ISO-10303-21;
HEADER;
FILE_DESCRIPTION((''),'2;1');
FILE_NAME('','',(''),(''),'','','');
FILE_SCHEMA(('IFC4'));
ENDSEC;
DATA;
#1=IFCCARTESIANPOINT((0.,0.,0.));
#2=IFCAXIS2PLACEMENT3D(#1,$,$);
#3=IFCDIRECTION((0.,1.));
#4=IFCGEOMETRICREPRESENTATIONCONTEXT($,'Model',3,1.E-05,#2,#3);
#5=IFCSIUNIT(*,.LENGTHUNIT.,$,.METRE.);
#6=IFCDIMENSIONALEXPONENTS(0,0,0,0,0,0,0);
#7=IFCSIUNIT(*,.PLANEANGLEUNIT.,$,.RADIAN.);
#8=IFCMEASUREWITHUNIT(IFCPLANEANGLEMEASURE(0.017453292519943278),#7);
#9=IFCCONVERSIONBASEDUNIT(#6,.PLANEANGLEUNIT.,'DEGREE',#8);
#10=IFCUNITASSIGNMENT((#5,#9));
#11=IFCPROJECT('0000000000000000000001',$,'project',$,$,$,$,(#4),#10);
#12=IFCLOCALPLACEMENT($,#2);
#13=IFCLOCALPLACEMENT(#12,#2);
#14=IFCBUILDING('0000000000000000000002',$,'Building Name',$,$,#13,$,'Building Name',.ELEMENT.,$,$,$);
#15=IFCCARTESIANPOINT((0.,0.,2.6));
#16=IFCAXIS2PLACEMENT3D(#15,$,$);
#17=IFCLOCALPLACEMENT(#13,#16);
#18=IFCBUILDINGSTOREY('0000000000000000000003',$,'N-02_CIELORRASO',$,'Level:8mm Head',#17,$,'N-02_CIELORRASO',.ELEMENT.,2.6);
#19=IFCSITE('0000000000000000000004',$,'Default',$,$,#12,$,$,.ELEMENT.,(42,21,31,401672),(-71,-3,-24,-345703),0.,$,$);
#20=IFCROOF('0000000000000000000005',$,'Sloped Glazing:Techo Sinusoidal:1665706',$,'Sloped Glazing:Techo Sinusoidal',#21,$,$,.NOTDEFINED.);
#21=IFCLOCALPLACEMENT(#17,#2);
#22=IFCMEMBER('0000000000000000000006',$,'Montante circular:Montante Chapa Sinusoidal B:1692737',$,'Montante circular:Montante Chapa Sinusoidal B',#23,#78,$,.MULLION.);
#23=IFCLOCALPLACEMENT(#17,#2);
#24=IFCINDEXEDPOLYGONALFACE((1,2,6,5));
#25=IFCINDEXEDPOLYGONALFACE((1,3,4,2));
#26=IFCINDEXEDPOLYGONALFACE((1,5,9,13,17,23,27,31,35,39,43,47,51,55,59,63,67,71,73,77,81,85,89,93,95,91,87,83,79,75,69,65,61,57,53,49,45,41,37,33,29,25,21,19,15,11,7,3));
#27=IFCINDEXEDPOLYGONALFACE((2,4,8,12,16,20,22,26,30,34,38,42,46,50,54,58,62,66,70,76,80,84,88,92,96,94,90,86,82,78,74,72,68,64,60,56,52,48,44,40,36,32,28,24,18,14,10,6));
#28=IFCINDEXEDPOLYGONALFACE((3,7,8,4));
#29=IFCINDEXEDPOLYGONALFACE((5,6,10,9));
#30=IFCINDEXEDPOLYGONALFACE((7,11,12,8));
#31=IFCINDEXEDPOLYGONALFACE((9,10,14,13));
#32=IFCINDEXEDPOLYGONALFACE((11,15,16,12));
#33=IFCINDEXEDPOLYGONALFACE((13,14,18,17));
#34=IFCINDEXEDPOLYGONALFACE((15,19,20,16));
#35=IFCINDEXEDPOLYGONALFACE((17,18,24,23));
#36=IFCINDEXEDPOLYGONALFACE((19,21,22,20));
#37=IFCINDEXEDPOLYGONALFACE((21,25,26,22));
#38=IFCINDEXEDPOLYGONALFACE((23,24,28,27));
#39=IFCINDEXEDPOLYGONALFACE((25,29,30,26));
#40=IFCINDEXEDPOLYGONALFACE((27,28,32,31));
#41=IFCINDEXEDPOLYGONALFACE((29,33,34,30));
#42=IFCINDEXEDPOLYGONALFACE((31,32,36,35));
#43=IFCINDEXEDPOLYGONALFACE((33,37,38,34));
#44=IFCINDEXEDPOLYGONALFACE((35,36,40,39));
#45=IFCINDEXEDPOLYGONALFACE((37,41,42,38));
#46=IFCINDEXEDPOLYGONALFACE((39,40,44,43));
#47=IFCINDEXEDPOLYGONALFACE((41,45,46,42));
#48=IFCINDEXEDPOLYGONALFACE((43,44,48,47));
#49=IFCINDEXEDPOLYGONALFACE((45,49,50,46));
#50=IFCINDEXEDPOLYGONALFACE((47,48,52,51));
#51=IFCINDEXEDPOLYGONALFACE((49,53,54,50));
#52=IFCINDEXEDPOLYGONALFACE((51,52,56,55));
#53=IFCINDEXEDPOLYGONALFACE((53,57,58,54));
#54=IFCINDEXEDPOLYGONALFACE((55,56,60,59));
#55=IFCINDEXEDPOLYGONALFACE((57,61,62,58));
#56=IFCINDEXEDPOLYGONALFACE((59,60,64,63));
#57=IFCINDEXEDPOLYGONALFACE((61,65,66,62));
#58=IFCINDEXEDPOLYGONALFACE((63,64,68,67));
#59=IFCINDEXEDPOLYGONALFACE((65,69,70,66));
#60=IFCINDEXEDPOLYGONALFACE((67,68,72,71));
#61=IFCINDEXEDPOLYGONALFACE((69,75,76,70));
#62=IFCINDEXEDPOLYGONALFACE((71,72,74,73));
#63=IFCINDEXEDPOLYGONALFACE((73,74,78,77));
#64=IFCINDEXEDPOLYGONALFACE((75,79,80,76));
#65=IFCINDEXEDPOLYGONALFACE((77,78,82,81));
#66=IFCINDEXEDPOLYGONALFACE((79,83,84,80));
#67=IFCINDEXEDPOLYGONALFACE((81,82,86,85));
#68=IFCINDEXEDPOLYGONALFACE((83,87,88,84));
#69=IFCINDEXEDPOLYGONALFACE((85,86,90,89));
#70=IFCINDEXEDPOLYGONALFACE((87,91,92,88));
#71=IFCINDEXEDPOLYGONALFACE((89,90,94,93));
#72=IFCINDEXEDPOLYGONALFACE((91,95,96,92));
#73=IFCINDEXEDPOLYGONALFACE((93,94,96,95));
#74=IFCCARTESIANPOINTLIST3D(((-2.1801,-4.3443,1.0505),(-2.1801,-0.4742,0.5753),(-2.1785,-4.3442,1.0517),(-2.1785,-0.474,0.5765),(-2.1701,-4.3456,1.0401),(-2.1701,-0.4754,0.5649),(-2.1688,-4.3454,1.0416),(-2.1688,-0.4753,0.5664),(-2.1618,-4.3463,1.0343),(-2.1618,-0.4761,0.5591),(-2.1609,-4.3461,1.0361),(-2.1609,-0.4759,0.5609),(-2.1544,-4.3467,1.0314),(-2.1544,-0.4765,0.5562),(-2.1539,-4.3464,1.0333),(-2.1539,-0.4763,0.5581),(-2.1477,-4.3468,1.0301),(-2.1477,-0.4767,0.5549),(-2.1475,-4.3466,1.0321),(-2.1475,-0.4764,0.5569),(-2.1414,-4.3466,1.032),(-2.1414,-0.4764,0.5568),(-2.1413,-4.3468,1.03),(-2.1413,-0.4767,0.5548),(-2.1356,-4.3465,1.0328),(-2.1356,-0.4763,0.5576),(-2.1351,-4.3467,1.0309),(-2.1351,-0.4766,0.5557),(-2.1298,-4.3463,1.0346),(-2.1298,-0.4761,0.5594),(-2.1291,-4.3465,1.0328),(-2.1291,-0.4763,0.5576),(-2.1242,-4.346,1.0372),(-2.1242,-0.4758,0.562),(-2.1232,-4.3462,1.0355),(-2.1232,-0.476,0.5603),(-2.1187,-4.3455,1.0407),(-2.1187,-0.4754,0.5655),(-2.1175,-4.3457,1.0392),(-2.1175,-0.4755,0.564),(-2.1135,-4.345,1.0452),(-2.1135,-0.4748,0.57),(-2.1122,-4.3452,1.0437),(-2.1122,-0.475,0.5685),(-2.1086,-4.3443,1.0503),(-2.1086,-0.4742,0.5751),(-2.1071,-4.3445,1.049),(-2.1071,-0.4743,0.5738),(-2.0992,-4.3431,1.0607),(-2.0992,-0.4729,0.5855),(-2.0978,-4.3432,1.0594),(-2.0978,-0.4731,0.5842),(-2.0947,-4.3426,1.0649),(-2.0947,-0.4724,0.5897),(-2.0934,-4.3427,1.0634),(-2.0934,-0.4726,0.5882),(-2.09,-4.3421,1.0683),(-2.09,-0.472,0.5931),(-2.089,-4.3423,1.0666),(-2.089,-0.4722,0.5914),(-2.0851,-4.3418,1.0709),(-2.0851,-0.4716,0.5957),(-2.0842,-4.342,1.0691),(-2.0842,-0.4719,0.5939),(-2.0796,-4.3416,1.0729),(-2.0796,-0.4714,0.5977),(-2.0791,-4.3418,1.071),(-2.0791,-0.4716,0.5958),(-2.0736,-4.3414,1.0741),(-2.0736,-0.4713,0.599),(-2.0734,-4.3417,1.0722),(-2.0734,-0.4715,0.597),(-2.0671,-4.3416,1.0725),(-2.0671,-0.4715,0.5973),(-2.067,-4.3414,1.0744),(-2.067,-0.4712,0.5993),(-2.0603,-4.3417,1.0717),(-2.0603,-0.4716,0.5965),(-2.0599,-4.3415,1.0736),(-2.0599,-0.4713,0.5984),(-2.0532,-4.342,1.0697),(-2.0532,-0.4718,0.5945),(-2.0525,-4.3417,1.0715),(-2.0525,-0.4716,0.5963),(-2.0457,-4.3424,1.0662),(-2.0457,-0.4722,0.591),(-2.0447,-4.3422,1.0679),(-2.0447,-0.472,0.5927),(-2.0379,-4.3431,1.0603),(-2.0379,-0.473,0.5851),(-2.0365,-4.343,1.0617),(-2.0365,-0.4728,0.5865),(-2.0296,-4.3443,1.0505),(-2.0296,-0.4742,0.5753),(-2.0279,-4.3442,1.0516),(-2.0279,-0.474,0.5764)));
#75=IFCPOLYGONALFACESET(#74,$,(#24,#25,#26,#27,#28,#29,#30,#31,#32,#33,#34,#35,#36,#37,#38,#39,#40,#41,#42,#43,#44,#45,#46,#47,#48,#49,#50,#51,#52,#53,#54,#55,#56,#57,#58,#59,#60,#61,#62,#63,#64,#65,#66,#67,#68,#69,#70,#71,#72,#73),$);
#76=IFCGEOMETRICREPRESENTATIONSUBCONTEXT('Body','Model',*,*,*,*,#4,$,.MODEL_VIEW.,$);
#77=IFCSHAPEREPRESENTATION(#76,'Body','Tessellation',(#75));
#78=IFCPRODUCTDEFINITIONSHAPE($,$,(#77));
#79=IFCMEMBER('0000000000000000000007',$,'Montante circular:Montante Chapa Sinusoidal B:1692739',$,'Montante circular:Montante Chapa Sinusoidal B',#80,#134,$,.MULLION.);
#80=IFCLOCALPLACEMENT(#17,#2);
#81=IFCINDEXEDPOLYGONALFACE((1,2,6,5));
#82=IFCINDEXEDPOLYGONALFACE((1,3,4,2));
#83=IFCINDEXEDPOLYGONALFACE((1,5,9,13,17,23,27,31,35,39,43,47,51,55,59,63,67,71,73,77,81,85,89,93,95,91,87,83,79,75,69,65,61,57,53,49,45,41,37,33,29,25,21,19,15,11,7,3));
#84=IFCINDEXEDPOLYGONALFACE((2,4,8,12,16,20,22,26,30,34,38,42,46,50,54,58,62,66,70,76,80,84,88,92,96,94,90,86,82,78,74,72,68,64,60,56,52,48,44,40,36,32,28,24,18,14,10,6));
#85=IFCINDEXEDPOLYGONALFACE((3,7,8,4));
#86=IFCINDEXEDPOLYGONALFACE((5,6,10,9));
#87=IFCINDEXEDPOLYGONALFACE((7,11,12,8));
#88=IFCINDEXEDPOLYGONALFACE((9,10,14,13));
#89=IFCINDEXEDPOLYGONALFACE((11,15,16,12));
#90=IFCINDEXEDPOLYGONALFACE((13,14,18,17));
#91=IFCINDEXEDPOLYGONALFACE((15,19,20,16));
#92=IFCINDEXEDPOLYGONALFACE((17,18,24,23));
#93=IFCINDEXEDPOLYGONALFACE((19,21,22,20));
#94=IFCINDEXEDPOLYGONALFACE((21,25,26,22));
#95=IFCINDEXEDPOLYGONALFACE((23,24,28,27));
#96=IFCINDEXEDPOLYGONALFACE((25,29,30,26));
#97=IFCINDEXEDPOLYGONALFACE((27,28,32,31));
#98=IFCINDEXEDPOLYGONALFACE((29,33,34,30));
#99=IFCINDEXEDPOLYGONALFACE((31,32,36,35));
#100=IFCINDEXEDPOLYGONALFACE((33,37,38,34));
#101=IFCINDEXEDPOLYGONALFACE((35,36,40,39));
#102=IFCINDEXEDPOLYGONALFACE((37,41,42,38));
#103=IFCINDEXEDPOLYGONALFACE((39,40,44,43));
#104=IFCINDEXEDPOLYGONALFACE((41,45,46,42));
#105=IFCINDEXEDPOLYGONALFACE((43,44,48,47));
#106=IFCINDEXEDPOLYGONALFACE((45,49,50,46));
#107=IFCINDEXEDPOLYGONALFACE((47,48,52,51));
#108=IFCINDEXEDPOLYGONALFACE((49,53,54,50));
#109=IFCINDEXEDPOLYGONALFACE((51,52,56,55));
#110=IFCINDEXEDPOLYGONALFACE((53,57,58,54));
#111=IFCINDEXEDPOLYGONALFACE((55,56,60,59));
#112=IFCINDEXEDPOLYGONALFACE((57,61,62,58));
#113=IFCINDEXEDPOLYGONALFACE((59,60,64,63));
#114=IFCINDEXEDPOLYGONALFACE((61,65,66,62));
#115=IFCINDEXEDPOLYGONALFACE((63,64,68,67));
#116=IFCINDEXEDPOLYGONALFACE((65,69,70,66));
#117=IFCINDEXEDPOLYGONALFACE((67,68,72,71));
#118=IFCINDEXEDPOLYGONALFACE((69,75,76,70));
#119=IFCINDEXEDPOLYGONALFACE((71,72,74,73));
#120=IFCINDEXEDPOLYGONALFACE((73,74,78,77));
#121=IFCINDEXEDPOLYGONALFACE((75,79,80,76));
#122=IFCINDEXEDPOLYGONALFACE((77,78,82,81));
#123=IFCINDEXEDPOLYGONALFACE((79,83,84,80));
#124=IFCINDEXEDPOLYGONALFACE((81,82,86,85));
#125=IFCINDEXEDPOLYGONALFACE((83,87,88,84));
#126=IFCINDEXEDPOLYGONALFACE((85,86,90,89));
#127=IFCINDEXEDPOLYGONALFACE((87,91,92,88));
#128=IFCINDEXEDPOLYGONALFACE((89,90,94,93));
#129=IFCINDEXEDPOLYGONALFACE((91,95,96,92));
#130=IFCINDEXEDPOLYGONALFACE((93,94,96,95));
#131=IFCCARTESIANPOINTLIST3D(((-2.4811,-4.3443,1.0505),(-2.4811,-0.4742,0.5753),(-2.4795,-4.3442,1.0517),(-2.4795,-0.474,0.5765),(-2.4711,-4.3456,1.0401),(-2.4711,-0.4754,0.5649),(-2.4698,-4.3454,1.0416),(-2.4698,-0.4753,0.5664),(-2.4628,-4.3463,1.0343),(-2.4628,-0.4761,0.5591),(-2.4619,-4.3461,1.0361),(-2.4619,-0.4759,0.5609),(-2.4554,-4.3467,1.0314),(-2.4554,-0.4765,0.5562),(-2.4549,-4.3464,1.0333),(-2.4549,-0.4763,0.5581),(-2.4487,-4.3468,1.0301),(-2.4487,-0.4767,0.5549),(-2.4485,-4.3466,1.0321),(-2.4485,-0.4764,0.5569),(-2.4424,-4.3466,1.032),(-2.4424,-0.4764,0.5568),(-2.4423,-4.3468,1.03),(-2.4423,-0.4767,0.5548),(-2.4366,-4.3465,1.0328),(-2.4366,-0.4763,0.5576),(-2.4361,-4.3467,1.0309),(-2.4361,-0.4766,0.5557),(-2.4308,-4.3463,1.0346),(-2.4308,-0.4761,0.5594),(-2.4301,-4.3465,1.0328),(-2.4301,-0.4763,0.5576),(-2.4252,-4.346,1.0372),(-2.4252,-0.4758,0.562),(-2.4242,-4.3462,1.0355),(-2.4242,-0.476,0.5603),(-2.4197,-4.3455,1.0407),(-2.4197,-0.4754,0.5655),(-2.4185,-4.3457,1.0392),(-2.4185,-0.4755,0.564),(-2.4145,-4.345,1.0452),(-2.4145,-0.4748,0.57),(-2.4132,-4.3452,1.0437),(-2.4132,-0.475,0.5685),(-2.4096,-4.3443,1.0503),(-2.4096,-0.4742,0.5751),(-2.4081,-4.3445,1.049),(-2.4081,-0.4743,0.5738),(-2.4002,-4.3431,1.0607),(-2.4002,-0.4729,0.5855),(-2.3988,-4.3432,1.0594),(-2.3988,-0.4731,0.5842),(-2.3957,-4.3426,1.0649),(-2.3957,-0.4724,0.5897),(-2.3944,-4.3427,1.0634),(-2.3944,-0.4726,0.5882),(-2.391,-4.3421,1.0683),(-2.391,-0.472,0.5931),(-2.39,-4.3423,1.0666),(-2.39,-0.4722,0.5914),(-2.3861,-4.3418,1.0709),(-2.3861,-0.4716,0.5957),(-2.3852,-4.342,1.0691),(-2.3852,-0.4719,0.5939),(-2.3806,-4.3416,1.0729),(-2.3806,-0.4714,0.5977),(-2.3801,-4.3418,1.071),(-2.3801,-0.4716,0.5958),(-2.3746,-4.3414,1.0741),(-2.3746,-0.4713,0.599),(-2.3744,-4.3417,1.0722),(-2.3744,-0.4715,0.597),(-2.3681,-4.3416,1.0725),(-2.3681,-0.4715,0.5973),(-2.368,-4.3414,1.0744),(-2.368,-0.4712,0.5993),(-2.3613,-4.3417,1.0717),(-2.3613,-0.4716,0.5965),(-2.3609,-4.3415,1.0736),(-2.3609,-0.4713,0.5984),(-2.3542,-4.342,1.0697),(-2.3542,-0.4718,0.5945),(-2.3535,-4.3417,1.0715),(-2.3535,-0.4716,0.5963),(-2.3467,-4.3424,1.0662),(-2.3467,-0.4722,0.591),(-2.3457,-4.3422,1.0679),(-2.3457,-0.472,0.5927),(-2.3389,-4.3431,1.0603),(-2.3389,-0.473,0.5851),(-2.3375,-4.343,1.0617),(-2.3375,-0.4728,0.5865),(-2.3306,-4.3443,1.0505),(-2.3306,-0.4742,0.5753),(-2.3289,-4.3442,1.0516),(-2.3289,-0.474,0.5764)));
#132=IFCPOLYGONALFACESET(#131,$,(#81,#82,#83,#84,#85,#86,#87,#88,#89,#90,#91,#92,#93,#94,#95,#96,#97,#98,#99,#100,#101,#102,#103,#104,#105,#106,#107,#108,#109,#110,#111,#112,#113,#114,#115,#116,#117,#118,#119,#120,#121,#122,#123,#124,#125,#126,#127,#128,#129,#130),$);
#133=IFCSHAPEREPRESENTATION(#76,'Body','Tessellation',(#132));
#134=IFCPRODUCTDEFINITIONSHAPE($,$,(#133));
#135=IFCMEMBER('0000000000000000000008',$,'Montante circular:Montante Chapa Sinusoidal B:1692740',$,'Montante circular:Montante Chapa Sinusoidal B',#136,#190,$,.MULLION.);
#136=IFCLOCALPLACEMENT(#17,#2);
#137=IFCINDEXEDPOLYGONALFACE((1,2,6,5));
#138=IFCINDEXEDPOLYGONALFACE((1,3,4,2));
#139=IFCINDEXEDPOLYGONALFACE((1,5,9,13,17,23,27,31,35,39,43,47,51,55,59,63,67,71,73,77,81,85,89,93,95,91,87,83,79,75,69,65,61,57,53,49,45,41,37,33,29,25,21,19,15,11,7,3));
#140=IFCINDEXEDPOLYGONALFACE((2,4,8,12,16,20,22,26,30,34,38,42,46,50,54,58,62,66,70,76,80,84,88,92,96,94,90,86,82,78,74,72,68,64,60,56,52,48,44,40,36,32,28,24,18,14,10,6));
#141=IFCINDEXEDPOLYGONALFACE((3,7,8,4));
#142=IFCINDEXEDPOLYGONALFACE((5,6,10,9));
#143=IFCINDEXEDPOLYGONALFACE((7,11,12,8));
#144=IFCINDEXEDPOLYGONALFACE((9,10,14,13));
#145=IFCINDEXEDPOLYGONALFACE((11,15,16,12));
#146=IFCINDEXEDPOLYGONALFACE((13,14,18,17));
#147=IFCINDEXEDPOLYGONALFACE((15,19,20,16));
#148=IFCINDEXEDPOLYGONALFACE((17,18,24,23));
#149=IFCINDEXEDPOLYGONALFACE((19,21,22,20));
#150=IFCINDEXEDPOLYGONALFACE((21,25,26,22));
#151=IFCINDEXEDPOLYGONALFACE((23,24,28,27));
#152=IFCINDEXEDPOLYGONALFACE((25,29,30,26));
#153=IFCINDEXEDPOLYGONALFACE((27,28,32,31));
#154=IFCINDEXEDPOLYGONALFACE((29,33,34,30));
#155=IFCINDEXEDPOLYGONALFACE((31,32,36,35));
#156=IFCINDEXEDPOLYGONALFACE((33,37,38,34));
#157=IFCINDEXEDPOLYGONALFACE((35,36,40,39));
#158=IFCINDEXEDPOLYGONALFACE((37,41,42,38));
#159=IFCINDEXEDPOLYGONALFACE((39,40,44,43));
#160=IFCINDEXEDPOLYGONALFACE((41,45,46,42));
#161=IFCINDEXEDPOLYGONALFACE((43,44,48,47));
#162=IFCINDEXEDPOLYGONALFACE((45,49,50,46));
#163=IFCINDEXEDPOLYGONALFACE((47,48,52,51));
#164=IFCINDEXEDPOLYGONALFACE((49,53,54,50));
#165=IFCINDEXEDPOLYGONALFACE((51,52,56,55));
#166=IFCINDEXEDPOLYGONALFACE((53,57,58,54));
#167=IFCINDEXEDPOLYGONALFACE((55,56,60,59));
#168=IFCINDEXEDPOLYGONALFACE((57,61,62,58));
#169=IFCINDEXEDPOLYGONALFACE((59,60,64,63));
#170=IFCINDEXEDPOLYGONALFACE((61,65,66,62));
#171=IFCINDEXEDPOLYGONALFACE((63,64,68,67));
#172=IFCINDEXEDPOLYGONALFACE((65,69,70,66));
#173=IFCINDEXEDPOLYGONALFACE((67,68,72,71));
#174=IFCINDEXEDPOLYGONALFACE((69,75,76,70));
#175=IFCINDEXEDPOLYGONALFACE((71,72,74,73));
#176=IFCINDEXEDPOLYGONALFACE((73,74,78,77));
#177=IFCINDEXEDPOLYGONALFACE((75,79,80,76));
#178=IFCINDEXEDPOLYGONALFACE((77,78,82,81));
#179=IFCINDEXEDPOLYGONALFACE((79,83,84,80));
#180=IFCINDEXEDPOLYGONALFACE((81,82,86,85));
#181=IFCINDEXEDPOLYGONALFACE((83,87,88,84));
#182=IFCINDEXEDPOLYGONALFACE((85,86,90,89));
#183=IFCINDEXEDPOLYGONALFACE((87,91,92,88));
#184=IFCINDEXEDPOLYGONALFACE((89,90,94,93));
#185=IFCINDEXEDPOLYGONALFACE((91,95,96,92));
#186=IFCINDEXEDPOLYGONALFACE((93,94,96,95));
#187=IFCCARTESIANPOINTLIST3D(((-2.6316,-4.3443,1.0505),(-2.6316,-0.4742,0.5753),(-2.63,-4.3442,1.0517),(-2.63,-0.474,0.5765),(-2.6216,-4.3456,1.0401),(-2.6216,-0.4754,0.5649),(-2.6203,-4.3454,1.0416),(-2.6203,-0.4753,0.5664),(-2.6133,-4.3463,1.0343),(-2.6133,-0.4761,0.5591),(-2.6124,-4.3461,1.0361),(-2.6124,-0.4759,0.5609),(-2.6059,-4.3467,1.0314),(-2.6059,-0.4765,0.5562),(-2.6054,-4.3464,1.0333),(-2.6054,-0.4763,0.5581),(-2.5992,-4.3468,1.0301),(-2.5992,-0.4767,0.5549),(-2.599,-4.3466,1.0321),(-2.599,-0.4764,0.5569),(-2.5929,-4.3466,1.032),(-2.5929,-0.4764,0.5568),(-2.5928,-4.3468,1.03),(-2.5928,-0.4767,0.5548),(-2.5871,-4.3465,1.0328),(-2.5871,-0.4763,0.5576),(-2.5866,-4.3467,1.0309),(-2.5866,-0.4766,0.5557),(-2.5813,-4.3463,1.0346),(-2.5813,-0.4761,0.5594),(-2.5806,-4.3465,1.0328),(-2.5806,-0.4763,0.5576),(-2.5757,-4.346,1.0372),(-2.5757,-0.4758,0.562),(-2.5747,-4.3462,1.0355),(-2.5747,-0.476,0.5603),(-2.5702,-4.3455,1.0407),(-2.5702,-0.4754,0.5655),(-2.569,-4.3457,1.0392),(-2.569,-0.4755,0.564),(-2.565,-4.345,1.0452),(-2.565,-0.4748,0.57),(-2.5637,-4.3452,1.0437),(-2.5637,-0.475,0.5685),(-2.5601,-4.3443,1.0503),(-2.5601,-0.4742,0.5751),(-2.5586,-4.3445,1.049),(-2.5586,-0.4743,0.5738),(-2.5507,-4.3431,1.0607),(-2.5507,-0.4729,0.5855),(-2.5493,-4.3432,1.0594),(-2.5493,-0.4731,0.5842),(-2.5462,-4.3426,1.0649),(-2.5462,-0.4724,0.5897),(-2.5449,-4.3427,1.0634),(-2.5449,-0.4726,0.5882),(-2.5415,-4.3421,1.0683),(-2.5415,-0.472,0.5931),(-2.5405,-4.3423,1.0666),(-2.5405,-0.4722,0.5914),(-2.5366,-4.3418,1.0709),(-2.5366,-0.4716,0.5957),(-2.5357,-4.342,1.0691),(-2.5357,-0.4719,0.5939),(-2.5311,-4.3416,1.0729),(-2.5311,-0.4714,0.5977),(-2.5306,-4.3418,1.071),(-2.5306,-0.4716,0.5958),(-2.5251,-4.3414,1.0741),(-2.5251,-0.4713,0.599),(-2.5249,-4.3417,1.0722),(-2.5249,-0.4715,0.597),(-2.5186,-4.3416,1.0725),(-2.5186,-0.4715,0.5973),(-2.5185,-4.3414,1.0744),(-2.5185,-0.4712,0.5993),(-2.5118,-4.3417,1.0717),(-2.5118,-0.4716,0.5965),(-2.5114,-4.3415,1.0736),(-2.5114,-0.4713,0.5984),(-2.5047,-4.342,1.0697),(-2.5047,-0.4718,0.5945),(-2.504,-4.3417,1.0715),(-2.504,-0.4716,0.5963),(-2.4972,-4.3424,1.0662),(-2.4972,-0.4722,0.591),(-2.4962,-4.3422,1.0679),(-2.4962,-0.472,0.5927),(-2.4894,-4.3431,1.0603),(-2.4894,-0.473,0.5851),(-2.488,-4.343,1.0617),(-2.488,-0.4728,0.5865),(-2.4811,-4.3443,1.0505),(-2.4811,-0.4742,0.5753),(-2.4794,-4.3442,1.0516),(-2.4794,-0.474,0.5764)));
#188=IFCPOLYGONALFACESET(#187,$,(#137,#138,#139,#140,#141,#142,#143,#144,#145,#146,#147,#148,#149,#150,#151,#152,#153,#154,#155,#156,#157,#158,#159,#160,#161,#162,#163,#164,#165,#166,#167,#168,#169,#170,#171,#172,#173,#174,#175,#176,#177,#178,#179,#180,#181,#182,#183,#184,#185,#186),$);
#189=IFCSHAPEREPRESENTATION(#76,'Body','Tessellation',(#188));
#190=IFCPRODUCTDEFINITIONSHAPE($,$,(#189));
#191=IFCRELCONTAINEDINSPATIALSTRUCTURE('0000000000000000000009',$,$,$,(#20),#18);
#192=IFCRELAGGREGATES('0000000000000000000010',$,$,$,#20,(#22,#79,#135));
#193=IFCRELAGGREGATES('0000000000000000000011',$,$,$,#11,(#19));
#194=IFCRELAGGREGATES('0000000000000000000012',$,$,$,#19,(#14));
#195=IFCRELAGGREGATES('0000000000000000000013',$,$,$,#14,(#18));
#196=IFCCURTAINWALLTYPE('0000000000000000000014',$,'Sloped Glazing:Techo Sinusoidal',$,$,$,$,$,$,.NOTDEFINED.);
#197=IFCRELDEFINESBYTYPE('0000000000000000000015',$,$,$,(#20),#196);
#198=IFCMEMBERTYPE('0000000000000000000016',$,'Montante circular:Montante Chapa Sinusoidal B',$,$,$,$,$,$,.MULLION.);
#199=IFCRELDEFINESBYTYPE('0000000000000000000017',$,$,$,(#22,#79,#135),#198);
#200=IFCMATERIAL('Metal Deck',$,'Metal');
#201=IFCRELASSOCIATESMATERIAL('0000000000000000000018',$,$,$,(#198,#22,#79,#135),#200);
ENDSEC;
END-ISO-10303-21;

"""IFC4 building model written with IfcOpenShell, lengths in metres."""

from ifc_helpers import new_model, entity, si_unit, converted_unit, direction, frame, origin, place, context, subcontext, project, spatial, indexed_curve, outline, extrude, source, transform, mapped, material, type_object, type_shapes, element, aggregate, save


model = new_model("IFC4")

# Units and contexts
model_context = context("Model", 3, precision=1e-05, world=origin(), true_north=direction((0.0, 1.0)))
body_context = subcontext(model_context, "Body", "Model", "MODEL_VIEW")
ifc_project = project(units=[si_unit("LENGTHUNIT", "METRE"), converted_unit("PLANEANGLEUNIT", "DEGREE", entity("IfcPlaneAngleMeasure", 0.017453292519943278), si_unit("PLANEANGLEUNIT", "RADIAN"), dimensions=[0, 0, 0, 0, 0, 0, 0])], contexts=[model_context])

# Site, building, storey
site_placement = place(None, origin())
site = spatial("IfcSite", under=ifc_project, at=site_placement, Name="Default", CompositionType="ELEMENT", RefLatitude=(42, 21, 31, 401672), RefLongitude=(-71, -3, -24, -345703), RefElevation=0.0)
building_placement = place(site_placement, origin())
building = spatial("IfcBuilding", under=site, at=building_placement, Name="Building Name", LongName="Building Name", CompositionType="ELEMENT")
storey_placement = place(building_placement, frame((0.0, 0.0, 2.6)))
storey = spatial("IfcBuildingStorey", under=building, at=storey_placement, Name="N-02_CIELORRASO", ObjectType="Level:8mm Head", LongName="N-02_CIELORRASO", CompositionType="ELEMENT", Elevation=2.6)

# Roof, members
curtain_wall_type = type_object("IfcCurtainWallType", Name="Sloped Glazing:Techo Sinusoidal", PredefinedType="NOTDEFINED")
ifc_material = material(Name="Metal Deck", Category="Metal")
roof_1_placement = place(storey_placement, frame((0.0, 0.0, -2.6)))
roof_1 = element("IfcRoof", 1, at=roof_1_placement, inside=storey, type_object=curtain_wall_type, Name="Sloped Glazing:Techo Sinusoidal:1665706", ObjectType="Sloped Glazing:Techo Sinusoidal", PredefinedType="NOTDEFINED")
member_type_1 = type_object("IfcMemberType", Name="Montante circular:Montante Chapa Sinusoidal B", PredefinedType="MULLION", material=ifc_material)
shared_shape_1 = source(origin(), body_context, "Body", "SweptSolid", [
    extrude(outline(indexed_curve([(0.0595, -0.0443), (0.0615, -0.0443), (0.0603, -0.031), (0.0572, -0.0213), (0.053, -0.0138), (0.0481, -0.0078), (0.0427, -0.003), (0.0372, 0.0005), (0.0315, 0.0029), (0.0259, 0.0044), (0.0203, 0.0051), (0.0146, 0.005), (0.0084, 0.0041), (-0.0053, 0.0009), (-0.0123, -0.0005), (-0.0191, -0.0012), (-0.0256, -0.001), (-0.0317, 0.0001), (-0.0375, 0.0019), (-0.0428, 0.0046), (-0.0477, 0.0081), (-0.0522, 0.0128), (-0.0563, 0.0191), (-0.0597, 0.0282), (-0.0617, 0.0421), (-0.0637, 0.042), (-0.0616, 0.0277), (-0.0581, 0.0182), (-0.0537, 0.0116), (-0.049, 0.0066), (-0.0438, 0.0028), (-0.0382, 0.0001), (-0.0322, -0.0019), (-0.0258, -0.003), (-0.019, -0.0032), (-0.012, -0.0025), (-0.0048, -0.0011), (0.0088, 0.0021), (0.0147, 0.003), (0.0202, 0.0031), (0.0255, 0.0024), (0.0309, 0.001), (0.0362, -0.0013), (0.0415, -0.0046), (0.0466, -0.0092), (0.0513, -0.0149), (0.0554, -0.0221), (0.0584, -0.0314), (0.0595, -0.0443)], self_intersect=False)), frame((-0.007, 0.0228, -3.8992), z_axis=(0.0, 0.0, 1.0), x_axis=(-0.819152, -0.573576, 0.0)), (0.0, 0.0, 1.0), 3.8992),
])
type_shapes(member_type_1, [shared_shape_1])
member_1_placement = place(roof_1_placement, frame((-2.1108, -4.3413, 3.6752), z_axis=(0.0, -0.992546, 0.121869), x_axis=(-1.0, 0.0, 0.0)))
member_1 = element("IfcMember", 2, at=member_1_placement, type_object=member_type_1, material=ifc_material, Name="Montante circular:Montante Chapa Sinusoidal B:1692737", ObjectType="Montante circular:Montante Chapa Sinusoidal B", PredefinedType="MULLION", context=body_context, shape_type="MappedRepresentation", body=[
    mapped(shared_shape_1, transform((0.0, 0.0, 0.0), scale=1.0)),
])
member_2_placement = place(roof_1_placement, frame((-2.4118, -4.3413, 3.6752), z_axis=(0.0, -0.992546, 0.121869), x_axis=(-1.0, 0.0, 0.0)))
member_2 = element("IfcMember", 3, at=member_2_placement, type_object=member_type_1, material=ifc_material, Name="Montante circular:Montante Chapa Sinusoidal B:1692739", ObjectType="Montante circular:Montante Chapa Sinusoidal B", PredefinedType="MULLION", context=body_context, shape_type="MappedRepresentation", body=[
    mapped(shared_shape_1, transform((0.0, 0.0, 0.0), scale=1.0)),
])
member_3_placement = place(roof_1_placement, frame((-2.5623, -4.3413, 3.6752), z_axis=(0.0, -0.992546, 0.121869), x_axis=(-1.0, 0.0, 0.0)))
member_3 = element("IfcMember", 4, at=member_3_placement, type_object=member_type_1, material=ifc_material, Name="Montante circular:Montante Chapa Sinusoidal B:1692740", ObjectType="Montante circular:Montante Chapa Sinusoidal B", PredefinedType="MULLION", context=body_context, shape_type="MappedRepresentation", body=[
    mapped(shared_shape_1, transform((0.0, 0.0, 0.0), scale=1.0)),
])
aggregate(roof_1, [member_1, member_2, member_3])

save(model, "model.ifc")
